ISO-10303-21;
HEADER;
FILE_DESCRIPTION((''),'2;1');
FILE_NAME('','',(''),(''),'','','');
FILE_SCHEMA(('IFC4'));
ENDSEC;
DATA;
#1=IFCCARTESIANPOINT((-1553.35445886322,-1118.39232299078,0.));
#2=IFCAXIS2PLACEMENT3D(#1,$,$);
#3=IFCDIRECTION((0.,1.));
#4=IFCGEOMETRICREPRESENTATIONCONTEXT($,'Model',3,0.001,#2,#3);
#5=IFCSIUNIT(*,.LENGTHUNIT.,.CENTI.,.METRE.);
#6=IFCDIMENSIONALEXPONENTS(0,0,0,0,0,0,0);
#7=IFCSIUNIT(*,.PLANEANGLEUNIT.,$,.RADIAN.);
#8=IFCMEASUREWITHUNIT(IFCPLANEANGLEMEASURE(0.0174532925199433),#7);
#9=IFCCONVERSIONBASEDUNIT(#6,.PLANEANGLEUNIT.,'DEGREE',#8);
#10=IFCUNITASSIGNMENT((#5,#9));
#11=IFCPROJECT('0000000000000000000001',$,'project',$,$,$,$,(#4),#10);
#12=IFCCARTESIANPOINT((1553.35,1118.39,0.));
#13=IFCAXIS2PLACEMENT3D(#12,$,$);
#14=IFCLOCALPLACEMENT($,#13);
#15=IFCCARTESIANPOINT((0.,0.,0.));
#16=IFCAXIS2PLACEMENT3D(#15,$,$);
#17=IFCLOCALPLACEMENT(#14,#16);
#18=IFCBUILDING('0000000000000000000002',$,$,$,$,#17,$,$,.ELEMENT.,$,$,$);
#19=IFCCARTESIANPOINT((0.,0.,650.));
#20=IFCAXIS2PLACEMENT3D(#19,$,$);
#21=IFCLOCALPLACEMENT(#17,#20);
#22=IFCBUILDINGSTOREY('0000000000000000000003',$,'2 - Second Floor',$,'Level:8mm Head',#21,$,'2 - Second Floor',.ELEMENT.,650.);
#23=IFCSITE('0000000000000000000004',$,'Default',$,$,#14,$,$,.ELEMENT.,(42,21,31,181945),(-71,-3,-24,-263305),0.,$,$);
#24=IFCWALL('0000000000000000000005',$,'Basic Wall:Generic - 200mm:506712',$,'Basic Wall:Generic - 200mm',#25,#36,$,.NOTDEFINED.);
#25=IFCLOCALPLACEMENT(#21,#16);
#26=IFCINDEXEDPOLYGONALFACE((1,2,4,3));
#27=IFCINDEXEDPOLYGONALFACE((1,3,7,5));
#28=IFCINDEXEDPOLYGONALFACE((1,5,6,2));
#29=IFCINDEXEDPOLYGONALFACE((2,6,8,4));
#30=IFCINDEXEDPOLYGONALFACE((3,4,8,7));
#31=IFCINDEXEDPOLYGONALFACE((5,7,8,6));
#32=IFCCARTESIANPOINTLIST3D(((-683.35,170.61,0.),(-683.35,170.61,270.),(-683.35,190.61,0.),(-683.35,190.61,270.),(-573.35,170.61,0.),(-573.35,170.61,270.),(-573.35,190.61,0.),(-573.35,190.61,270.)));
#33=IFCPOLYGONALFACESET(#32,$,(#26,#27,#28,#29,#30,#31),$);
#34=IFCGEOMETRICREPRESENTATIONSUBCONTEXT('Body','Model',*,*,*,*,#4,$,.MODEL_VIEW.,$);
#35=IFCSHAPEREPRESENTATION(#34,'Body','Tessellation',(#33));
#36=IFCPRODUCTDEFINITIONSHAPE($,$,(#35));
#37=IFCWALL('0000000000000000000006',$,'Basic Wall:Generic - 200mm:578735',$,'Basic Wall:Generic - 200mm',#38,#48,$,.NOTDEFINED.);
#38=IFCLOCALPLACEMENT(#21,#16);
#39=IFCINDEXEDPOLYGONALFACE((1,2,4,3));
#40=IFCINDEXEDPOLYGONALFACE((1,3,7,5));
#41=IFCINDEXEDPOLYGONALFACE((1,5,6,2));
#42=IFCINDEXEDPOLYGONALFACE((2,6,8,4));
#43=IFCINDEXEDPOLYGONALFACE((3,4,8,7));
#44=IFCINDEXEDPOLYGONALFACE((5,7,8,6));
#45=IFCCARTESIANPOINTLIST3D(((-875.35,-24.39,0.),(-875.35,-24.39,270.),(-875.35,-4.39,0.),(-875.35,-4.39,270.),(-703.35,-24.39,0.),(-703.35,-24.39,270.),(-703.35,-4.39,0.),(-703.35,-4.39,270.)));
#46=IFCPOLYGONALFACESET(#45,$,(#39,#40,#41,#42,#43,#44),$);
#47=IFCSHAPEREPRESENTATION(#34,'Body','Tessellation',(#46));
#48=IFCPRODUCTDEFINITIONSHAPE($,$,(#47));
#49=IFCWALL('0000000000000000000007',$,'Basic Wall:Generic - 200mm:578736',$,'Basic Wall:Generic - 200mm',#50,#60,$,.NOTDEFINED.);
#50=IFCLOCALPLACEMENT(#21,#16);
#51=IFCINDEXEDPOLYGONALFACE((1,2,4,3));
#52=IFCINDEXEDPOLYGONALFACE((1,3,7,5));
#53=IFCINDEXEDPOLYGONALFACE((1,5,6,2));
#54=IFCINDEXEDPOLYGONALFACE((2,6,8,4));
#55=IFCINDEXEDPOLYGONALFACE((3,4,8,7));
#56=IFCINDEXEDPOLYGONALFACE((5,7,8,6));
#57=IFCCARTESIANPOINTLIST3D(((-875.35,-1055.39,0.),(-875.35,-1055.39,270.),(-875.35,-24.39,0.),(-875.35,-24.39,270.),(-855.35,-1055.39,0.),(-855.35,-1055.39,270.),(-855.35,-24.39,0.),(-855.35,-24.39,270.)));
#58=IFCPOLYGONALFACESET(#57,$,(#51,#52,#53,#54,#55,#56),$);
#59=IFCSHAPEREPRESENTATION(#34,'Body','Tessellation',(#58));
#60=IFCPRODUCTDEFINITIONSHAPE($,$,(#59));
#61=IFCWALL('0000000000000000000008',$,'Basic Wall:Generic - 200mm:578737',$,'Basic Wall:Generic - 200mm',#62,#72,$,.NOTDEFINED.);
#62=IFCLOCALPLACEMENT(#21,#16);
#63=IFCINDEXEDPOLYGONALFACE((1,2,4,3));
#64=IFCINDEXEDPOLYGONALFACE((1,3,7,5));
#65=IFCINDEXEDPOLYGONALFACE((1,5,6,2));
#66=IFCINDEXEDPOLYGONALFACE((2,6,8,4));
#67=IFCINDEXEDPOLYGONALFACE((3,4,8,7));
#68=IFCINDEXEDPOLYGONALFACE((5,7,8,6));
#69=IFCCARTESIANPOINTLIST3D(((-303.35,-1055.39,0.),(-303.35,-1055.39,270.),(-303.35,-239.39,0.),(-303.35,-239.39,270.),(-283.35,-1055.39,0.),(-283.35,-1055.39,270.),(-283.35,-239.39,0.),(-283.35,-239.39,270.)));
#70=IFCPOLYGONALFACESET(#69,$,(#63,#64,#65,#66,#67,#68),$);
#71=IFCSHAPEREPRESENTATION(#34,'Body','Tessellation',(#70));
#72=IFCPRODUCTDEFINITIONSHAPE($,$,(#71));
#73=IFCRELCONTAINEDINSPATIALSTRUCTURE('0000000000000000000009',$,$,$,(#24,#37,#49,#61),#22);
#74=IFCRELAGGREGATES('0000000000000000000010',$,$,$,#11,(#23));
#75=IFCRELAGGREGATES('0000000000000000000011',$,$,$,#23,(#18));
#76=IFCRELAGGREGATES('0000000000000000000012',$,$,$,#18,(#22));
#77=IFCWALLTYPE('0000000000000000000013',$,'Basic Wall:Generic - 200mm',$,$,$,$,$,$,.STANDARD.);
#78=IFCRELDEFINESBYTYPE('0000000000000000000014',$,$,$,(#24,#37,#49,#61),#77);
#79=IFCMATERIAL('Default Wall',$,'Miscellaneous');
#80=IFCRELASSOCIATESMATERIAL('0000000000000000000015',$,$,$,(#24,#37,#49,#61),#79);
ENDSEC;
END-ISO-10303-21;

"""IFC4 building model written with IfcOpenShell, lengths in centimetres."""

from ifc_helpers import new_model, entity, si_unit, converted_unit, direction, frame, origin, place, context, subcontext, project, spatial, indexed_curve, outline, extrude, material, type_object, element, save


model = new_model("IFC4")

# Units and contexts
model_context = context("Model", 3, precision=0.001, world=frame((-1553.35445886322, -1118.39232299078, 0.0)), true_north=direction((0.0, 1.0)))
body_context = subcontext(model_context, "Body", "Model", "MODEL_VIEW")
ifc_project = project(units=[si_unit("LENGTHUNIT", "METRE", prefix="CENTI"), converted_unit("PLANEANGLEUNIT", "DEGREE", entity("IfcPlaneAngleMeasure", 0.0174532925199433), si_unit("PLANEANGLEUNIT", "RADIAN"), dimensions=[0, 0, 0, 0, 0, 0, 0])], contexts=[model_context])

# Site, building, storey
site_placement = place(None, frame((1553.35, 1118.39, 0.0)))
site = spatial("IfcSite", under=ifc_project, at=site_placement, Name="Default", CompositionType="ELEMENT", RefLatitude=(42, 21, 31, 181945), RefLongitude=(-71, -3, -24, -263305), RefElevation=0.0)
building_placement = place(site_placement, origin())
building = spatial("IfcBuilding", under=site, at=building_placement, CompositionType="ELEMENT")
storey_placement = place(building_placement, frame((0.0, 0.0, 650.0)))
storey = spatial("IfcBuildingStorey", under=building, at=storey_placement, Name="2 - Second Floor", ObjectType="Level:8mm Head", LongName="2 - Second Floor", CompositionType="ELEMENT", Elevation=650.0)

# Walls
ifc_material_1 = material(Name="Default Wall", Category="Miscellaneous")
wall_type_1 = type_object("IfcWallType", Name="Basic Wall:Generic - 200mm", PredefinedType="STANDARD")
wall_1_placement = place(storey_placement, frame((-683.35, 180.61, 0.0)))
element("IfcWall", 1, at=wall_1_placement, inside=storey, type_object=wall_type_1, material=ifc_material_1, Name="Basic Wall:Generic - 200mm:506712", ObjectType="Basic Wall:Generic - 200mm", PredefinedType="NOTDEFINED", context=body_context, shape_type="SweptSolid", body=[
    extrude(outline(indexed_curve([(110.0, 10.0), (0.0, 10.0), (0.0, -10.0), (110.0, -10.0), (110.0, 10.0)], self_intersect=False)), origin(), (0.0, 0.0, 1.0), 270.0),
])
wall_2_placement = place(storey_placement, frame((-703.35, -14.39, 0.0), z_axis=(0.0, 0.0, 1.0), x_axis=(-1.0, 0.0, 0.0)))
element("IfcWall", 2, at=wall_2_placement, inside=storey, type_object=wall_type_1, material=ifc_material_1, Name="Basic Wall:Generic - 200mm:578735", ObjectType="Basic Wall:Generic - 200mm", PredefinedType="NOTDEFINED", context=body_context, shape_type="SweptSolid", body=[
    extrude(outline(indexed_curve([(172.0, 10.0), (0.0, 10.0), (0.0, -10.0), (172.0, -10.0), (172.0, 10.0)], self_intersect=False)), origin(), (0.0, 0.0, 1.0), 270.0),
])
wall_3_placement = place(storey_placement, frame((-865.35, -24.39, 0.0), z_axis=(0.0, 0.0, 1.0), x_axis=(0.0, -1.0, 0.0)))
element("IfcWall", 3, at=wall_3_placement, inside=storey, type_object=wall_type_1, material=ifc_material_1, Name="Basic Wall:Generic - 200mm:578736", ObjectType="Basic Wall:Generic - 200mm", PredefinedType="NOTDEFINED", context=body_context, shape_type="SweptSolid", body=[
    extrude(outline(indexed_curve([(1031.0, 10.0), (0.0, 10.0), (0.0, -10.0), (1031.0, -10.0), (1031.0, 10.0)], self_intersect=False)), origin(), (0.0, 0.0, 1.0), 270.0),
])
wall_4_placement = place(storey_placement, frame((-293.35, -239.39, 0.0), z_axis=(0.0, 0.0, 1.0), x_axis=(0.0, -1.0, 0.0)))
element("IfcWall", 4, at=wall_4_placement, inside=storey, type_object=wall_type_1, material=ifc_material_1, Name="Basic Wall:Generic - 200mm:578737", ObjectType="Basic Wall:Generic - 200mm", PredefinedType="NOTDEFINED", context=body_context, shape_type="SweptSolid", body=[
    extrude(outline(indexed_curve([(816.0, 10.0), (0.0, 10.0), (0.0, -10.0), (816.0, -10.0), (816.0, 10.0)], self_intersect=False)), origin(), (0.0, 0.0, 1.0), 270.0),
])

save(model, "model.ifc")
